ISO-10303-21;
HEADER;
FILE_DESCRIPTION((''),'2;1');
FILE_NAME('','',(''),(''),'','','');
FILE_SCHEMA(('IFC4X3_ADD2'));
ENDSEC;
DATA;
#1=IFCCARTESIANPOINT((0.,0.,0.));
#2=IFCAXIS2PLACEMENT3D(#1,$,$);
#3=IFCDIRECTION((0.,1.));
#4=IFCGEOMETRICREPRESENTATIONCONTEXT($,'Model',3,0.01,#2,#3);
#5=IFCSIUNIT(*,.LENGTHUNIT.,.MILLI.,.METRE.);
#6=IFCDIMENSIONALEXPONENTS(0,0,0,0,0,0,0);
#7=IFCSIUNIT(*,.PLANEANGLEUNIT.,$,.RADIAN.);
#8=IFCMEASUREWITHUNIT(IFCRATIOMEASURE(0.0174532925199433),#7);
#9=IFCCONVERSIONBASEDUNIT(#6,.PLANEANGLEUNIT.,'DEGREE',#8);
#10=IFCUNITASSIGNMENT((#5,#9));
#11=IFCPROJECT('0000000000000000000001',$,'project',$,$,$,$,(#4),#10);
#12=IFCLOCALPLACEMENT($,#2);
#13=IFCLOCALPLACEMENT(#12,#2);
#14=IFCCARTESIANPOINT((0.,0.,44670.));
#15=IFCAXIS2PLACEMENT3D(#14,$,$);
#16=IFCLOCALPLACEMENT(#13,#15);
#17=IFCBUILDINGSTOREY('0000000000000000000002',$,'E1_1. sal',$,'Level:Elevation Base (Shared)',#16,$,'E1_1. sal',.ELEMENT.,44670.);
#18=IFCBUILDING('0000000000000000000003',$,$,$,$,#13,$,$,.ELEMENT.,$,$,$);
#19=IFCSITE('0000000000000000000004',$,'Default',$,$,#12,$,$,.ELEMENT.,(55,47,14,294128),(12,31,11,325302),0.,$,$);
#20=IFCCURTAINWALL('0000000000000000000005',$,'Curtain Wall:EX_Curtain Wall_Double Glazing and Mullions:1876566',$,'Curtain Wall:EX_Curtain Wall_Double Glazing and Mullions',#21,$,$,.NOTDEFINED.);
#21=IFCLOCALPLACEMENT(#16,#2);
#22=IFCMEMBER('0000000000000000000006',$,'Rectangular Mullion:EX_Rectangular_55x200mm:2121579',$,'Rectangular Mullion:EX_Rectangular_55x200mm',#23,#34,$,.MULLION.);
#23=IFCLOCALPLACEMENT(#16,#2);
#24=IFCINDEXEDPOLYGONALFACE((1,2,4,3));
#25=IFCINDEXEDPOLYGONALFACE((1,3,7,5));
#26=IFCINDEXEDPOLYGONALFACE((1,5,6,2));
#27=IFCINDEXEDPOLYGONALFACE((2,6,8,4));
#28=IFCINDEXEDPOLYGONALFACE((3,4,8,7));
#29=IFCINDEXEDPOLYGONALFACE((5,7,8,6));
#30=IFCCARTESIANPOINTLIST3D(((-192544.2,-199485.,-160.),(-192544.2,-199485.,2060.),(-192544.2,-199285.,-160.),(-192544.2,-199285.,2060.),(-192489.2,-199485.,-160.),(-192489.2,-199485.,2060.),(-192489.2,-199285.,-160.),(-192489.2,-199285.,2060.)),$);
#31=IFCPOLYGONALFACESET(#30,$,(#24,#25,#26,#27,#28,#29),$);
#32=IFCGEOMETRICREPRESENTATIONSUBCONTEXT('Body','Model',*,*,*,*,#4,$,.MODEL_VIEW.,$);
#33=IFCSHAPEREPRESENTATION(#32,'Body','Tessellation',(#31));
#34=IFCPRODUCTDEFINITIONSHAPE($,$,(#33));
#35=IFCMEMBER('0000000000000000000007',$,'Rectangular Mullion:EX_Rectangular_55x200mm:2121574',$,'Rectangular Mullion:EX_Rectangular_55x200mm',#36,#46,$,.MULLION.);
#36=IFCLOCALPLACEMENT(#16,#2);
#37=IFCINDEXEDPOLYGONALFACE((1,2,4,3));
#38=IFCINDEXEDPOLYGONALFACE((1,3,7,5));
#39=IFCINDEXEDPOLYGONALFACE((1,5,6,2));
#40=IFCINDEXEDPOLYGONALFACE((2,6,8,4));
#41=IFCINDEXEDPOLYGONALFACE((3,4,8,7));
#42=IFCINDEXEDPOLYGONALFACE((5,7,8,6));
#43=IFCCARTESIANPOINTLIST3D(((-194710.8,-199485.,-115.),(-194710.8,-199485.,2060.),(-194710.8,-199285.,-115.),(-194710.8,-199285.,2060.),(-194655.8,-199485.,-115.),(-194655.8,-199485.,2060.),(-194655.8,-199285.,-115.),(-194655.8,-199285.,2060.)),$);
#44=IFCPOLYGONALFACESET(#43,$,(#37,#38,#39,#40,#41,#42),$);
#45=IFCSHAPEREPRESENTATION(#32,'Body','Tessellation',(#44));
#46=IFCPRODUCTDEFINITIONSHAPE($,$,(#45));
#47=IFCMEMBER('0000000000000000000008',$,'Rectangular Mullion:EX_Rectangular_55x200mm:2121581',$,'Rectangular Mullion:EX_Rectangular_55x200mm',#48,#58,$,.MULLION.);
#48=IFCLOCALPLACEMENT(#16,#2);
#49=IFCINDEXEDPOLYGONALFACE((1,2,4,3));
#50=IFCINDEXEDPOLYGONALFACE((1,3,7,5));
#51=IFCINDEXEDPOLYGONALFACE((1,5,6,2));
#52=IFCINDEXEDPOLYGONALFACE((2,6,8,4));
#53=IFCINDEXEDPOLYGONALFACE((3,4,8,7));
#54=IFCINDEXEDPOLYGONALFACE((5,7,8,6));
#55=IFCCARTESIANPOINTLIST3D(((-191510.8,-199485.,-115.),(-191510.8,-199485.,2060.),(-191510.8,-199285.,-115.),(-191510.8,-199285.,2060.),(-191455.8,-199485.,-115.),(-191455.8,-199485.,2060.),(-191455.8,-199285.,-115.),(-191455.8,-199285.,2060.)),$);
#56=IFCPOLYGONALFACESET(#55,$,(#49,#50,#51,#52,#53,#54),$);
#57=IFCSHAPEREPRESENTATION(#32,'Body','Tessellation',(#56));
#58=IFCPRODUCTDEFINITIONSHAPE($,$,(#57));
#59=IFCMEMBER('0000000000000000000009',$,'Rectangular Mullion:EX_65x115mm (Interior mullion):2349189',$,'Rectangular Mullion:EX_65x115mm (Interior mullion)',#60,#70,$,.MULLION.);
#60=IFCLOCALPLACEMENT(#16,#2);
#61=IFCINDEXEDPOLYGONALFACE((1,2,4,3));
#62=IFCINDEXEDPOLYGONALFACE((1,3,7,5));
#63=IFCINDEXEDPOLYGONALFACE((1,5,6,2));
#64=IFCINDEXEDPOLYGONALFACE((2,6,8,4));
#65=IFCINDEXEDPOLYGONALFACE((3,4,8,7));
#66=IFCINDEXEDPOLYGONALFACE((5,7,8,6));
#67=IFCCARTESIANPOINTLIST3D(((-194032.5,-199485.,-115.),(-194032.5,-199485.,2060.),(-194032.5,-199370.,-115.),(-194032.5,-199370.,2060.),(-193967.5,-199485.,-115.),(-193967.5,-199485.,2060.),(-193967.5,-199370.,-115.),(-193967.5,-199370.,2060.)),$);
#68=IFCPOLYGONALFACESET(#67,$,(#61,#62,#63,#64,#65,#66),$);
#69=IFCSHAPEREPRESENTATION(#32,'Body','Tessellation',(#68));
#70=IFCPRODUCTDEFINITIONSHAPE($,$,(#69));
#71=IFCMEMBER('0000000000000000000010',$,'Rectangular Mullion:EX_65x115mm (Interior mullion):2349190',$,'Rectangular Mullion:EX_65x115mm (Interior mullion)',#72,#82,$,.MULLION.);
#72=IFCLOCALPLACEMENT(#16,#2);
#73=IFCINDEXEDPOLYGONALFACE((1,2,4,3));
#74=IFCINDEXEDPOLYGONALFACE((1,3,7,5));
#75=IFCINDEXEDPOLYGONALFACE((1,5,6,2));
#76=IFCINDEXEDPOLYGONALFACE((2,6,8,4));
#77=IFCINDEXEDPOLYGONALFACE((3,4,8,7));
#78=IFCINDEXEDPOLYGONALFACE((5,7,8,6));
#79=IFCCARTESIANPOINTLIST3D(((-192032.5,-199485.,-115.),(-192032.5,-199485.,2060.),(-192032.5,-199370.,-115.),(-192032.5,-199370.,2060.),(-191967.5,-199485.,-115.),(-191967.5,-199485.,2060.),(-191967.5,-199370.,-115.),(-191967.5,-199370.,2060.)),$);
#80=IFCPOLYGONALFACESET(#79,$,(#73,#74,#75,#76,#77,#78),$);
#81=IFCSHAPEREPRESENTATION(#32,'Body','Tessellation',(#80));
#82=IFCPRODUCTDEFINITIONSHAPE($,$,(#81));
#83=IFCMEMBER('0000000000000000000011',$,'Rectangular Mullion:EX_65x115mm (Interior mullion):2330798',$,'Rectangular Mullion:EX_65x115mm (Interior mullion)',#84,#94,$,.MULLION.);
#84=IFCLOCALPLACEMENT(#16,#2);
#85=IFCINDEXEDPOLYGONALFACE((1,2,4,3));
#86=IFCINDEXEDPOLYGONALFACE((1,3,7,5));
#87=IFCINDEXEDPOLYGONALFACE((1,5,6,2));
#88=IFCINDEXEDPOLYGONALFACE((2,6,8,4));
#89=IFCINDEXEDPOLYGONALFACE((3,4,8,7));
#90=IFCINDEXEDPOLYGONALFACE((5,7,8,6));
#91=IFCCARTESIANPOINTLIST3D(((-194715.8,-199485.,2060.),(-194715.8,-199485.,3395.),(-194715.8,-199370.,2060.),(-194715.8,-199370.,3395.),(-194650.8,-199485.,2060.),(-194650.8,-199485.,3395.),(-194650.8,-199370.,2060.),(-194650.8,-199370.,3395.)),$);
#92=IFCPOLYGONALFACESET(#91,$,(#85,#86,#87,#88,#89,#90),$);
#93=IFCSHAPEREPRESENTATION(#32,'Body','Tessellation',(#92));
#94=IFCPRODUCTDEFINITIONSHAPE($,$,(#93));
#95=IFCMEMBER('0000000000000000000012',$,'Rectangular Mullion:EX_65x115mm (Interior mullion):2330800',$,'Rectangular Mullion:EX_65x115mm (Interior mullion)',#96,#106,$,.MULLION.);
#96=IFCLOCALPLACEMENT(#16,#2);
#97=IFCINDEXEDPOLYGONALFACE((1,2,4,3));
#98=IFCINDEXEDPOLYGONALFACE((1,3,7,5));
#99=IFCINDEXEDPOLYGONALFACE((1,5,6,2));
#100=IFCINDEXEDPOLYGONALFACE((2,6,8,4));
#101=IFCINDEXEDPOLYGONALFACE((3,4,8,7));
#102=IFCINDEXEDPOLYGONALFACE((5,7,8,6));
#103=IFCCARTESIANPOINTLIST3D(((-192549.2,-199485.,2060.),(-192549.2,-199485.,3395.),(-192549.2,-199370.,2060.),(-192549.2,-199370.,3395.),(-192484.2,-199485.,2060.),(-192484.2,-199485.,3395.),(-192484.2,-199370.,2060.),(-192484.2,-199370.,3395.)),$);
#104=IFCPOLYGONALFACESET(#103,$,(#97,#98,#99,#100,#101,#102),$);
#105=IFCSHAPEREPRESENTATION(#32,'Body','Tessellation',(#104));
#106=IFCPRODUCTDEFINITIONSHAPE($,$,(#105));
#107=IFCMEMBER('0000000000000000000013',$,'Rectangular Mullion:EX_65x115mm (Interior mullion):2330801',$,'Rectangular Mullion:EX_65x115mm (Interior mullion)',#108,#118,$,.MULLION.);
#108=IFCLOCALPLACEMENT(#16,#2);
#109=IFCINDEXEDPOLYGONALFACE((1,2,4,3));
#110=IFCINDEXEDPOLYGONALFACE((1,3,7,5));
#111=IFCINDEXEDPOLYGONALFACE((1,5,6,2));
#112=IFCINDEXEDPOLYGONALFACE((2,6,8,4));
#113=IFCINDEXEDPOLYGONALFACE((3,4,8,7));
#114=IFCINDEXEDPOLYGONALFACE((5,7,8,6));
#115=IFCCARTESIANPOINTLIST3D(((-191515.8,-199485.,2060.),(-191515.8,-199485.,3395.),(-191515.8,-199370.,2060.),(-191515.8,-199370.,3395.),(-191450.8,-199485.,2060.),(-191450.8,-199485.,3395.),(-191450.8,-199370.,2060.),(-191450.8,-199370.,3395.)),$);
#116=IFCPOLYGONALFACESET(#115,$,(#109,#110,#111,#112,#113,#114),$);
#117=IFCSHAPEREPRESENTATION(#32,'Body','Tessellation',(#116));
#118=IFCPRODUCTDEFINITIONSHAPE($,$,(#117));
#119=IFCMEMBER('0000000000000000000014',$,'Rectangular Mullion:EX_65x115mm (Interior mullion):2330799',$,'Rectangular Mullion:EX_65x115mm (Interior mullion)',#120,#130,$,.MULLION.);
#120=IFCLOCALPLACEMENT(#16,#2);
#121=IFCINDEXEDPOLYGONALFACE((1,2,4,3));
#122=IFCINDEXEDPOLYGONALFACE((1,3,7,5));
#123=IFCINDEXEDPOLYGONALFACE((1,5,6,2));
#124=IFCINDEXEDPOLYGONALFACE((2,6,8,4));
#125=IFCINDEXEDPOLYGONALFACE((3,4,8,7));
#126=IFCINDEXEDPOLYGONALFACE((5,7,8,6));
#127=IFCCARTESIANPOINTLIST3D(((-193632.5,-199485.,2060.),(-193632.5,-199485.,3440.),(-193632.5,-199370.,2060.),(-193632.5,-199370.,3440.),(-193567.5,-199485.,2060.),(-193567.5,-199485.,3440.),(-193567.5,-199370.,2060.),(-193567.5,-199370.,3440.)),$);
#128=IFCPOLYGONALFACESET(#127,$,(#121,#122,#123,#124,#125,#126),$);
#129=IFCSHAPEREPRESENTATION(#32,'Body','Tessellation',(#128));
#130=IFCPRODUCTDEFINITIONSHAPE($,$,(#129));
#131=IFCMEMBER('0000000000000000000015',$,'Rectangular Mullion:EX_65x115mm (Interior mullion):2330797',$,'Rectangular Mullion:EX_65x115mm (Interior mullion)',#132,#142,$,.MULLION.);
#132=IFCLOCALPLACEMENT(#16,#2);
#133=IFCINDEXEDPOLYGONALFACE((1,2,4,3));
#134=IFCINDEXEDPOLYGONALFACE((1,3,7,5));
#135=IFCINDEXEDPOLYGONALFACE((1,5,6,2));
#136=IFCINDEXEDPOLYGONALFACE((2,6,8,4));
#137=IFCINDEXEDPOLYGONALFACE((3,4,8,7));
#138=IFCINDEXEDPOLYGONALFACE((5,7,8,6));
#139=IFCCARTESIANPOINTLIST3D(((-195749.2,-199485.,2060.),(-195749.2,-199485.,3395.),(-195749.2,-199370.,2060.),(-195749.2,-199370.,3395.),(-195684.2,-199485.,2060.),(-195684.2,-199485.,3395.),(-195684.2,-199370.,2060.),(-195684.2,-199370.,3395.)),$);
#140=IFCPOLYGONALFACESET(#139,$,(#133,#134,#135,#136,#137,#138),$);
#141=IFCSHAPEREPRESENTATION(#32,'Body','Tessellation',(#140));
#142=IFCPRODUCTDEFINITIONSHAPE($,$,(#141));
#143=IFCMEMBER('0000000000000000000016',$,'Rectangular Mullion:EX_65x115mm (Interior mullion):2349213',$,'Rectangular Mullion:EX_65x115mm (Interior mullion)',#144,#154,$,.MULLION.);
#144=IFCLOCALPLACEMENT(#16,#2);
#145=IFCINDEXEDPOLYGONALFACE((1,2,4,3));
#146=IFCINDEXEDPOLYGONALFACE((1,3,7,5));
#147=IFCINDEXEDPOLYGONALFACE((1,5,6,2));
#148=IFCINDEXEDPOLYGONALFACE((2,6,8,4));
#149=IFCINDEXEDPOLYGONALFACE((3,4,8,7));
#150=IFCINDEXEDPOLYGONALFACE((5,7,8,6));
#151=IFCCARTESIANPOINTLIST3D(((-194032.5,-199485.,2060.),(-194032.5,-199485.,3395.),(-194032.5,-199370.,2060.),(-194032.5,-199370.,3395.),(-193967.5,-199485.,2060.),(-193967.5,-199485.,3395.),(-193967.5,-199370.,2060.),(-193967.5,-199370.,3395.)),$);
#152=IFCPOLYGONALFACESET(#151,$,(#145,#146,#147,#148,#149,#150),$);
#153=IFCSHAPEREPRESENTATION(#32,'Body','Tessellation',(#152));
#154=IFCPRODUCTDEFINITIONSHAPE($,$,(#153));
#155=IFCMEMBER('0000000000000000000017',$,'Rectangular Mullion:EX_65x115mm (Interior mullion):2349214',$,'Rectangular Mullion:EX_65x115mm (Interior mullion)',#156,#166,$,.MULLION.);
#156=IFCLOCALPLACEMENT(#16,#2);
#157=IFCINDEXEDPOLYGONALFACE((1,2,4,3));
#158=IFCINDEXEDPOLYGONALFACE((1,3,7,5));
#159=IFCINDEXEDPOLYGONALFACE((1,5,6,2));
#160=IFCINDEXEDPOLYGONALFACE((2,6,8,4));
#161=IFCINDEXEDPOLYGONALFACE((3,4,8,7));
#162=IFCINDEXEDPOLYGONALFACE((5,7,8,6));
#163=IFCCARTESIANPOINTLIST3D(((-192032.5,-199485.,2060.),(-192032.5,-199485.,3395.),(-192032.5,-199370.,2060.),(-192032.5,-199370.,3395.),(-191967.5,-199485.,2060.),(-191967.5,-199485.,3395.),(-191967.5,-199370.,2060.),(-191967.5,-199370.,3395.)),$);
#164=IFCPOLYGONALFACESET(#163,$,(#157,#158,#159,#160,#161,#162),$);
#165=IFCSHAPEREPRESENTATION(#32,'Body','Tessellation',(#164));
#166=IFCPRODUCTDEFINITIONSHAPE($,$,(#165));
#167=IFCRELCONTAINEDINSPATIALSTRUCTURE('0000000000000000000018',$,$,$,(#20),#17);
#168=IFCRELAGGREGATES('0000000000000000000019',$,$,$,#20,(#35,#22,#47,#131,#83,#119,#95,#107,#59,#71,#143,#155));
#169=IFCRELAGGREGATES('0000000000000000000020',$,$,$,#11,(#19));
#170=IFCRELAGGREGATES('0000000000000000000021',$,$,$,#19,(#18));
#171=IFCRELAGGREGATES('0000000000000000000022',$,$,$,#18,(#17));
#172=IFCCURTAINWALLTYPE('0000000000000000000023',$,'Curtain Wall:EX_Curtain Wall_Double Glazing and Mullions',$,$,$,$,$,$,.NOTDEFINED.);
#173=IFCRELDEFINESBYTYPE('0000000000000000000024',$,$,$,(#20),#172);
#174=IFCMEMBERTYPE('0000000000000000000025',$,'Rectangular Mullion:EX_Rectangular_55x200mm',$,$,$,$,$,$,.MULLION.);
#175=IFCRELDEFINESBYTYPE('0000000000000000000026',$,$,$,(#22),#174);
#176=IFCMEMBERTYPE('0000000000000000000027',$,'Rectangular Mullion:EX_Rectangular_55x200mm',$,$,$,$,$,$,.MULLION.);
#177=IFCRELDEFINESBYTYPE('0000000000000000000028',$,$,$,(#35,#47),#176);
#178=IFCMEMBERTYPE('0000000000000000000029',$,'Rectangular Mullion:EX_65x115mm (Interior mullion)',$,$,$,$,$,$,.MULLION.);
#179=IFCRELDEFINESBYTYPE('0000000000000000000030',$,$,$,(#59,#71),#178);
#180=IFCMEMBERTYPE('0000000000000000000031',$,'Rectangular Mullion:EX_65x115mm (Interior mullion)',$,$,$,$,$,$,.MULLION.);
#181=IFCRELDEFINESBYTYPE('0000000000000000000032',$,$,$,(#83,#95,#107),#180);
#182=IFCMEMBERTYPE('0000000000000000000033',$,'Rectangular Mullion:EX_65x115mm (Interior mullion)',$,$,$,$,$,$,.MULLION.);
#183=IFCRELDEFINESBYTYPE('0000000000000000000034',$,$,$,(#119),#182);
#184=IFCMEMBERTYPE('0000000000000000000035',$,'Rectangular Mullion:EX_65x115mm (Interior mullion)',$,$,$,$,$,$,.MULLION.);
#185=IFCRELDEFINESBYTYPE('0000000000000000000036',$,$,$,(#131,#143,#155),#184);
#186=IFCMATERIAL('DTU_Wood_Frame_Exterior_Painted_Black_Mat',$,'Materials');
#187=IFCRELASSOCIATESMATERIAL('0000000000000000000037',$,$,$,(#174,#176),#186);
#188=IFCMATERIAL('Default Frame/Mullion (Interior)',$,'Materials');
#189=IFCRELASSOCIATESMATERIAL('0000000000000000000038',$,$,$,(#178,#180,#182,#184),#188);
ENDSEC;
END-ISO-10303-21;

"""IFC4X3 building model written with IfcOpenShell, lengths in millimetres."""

from ifc_helpers import new_model, entity, si_unit, converted_unit, direction, frame, origin, origin_2d_with_axis, place, context, subcontext, project, spatial, rectangle, extrude, source, transform, mapped, material, material_profile, profile_set, type_object, type_shapes, element, aggregate, save


model = new_model("IFC4X3")

# Units and contexts
model_context = context("Model", 3, precision=0.01, world=origin(), true_north=direction((0.0, 1.0)))
body_context = subcontext(model_context, "Body", "Model", "MODEL_VIEW")
ifc_project = project(units=[si_unit("LENGTHUNIT", "METRE", prefix="MILLI"), converted_unit("PLANEANGLEUNIT", "DEGREE", entity("IfcRatioMeasure", 0.0174532925199433), si_unit("PLANEANGLEUNIT", "RADIAN"), dimensions=[0, 0, 0, 0, 0, 0, 0])], contexts=[model_context])

# Site, building, storey
site_placement = place(None, origin())
site = spatial("IfcSite", under=ifc_project, at=site_placement, Name="Default", CompositionType="ELEMENT", RefLatitude=(55, 47, 14, 294128), RefLongitude=(12, 31, 11, 325302), RefElevation=0.0)
building_placement = place(site_placement, origin())
building = spatial("IfcBuilding", under=site, at=building_placement, CompositionType="ELEMENT")
storey_placement = place(building_placement, frame((0.0, 0.0, 44670.0)))
storey = spatial("IfcBuildingStorey", under=building, at=storey_placement, Name="E1_1. sal", ObjectType="Level:Elevation Base (Shared)", LongName="E1_1. sal", CompositionType="ELEMENT", Elevation=44670.0)

# Curtain wall, members
curtain_wall_type = type_object("IfcCurtainWallType", Name="Curtain Wall:EX_Curtain Wall_Double Glazing and Mullions", PredefinedType="NOTDEFINED")
curtain_wall_placement = place(storey_placement, frame((0.0, 0.0, -44670.0)))
curtain_wall = element("IfcCurtainWall", 1, at=curtain_wall_placement, inside=storey, type_object=curtain_wall_type, Name="Curtain Wall:EX_Curtain Wall_Double Glazing and Mullions:1876566", ObjectType="Curtain Wall:EX_Curtain Wall_Double Glazing and Mullions", PredefinedType="NOTDEFINED")
ifc_material_1 = material(Name="DTU_Wood_Frame_Exterior_Painted_Black_Mat", Category="Materials")
ifc_material_profile_1 = material_profile(ifc_material_1, rectangle(XDim=200.0, YDim=55.0, at=origin_2d_with_axis()), Name="EX_Rectangular_55x200mm")
ifc_profile_set_1 = profile_set([ifc_material_profile_1], Name="EX_Rectangular_55x200mm")
member_type_1 = type_object("IfcMemberType", Name="Rectangular Mullion:EX_Rectangular_55x200mm", PredefinedType="MULLION", material=ifc_profile_set_1)
shared_shape_1 = source(origin(), body_context, "Body", "SweptSolid", [
    extrude(rectangle(XDim=200.0, YDim=55.0, at=origin_2d_with_axis()), frame((0.0, -100.0, -2220.0), z_axis=(0.0, 0.0, 1.0), x_axis=(0.0, -1.0, 0.0)), (0.0, 0.0, 1.0), 2220.0),
])
type_shapes(member_type_1, [shared_shape_1])
member_1_placement = place(curtain_wall_placement, frame((-192516.7, -199485.0, 44510.0), z_axis=(0.0, 0.0, -1.0), x_axis=(1.0, 0.0, 0.0)))
member_1 = element("IfcMember", 2, at=member_1_placement, type_object=member_type_1, Name="Rectangular Mullion:EX_Rectangular_55x200mm:2121579", ObjectType="Rectangular Mullion:EX_Rectangular_55x200mm", PredefinedType="MULLION", context=body_context, shape_type="MappedRepresentation", body=[
    mapped(shared_shape_1, transform((0.0, 0.0, 0.0), scale=1.0)),
])
member_type_2 = type_object("IfcMemberType", Name="Rectangular Mullion:EX_Rectangular_55x200mm", PredefinedType="MULLION", material=ifc_profile_set_1)
shared_shape_2 = source(origin(), body_context, "Body", "SweptSolid", [
    extrude(rectangle(XDim=200.0, YDim=55.0, at=origin_2d_with_axis()), frame((0.0, -100.0, -2175.0), z_axis=(0.0, 0.0, 1.0), x_axis=(0.0, -1.0, 0.0)), (0.0, 0.0, 1.0), 2175.0),
])
type_shapes(member_type_2, [shared_shape_2])
member_2_placement = place(curtain_wall_placement, frame((-194683.3, -199485.0, 44555.0), z_axis=(0.0, 0.0, -1.0), x_axis=(1.0, 0.0, 0.0)))
member_2 = element("IfcMember", 3, at=member_2_placement, type_object=member_type_2, Name="Rectangular Mullion:EX_Rectangular_55x200mm:2121574", ObjectType="Rectangular Mullion:EX_Rectangular_55x200mm", PredefinedType="MULLION", context=body_context, shape_type="MappedRepresentation", body=[
    mapped(shared_shape_2, transform((0.0, 0.0, 0.0), scale=1.0)),
])
member_3_placement = place(curtain_wall_placement, frame((-191483.3, -199485.0, 44555.0), z_axis=(0.0, 0.0, -1.0), x_axis=(1.0, 0.0, 0.0)))
member_3 = element("IfcMember", 4, at=member_3_placement, type_object=member_type_2, Name="Rectangular Mullion:EX_Rectangular_55x200mm:2121581", ObjectType="Rectangular Mullion:EX_Rectangular_55x200mm", PredefinedType="MULLION", context=body_context, shape_type="MappedRepresentation", body=[
    mapped(shared_shape_2, transform((0.0, 0.0, 0.0), scale=1.0)),
])
ifc_material_2 = material(Name="Default Frame/Mullion (Interior)", Category="Materials")
ifc_material_profile_2 = material_profile(ifc_material_2, rectangle(XDim=115.0, YDim=65.0, at=origin_2d_with_axis()), Name="EX_65x115mm (Interior mullion)")
ifc_profile_set_2 = profile_set([ifc_material_profile_2], Name="EX_65x115mm (Interior mullion)")
member_type_3 = type_object("IfcMemberType", Name="Rectangular Mullion:EX_65x115mm (Interior mullion)", PredefinedType="MULLION", material=ifc_profile_set_2)
shared_shape_3 = source(origin(), body_context, "Body", "SweptSolid", [
    extrude(rectangle(XDim=115.0, YDim=65.0, at=origin_2d_with_axis()), frame((0.0, -57.5, -2175.0), z_axis=(0.0, 0.0, 1.0), x_axis=(0.0, -1.0, 0.0)), (0.0, 0.0, 1.0), 2175.0),
])
type_shapes(member_type_3, [shared_shape_3])
member_4_placement = place(curtain_wall_placement, frame((-194000.0, -199485.0, 44555.0), z_axis=(0.0, 0.0, -1.0), x_axis=(1.0, 0.0, 0.0)))
member_4 = element("IfcMember", 5, at=member_4_placement, type_object=member_type_3, Name="Rectangular Mullion:EX_65x115mm (Interior mullion):2349189", ObjectType="Rectangular Mullion:EX_65x115mm (Interior mullion)", PredefinedType="MULLION", context=body_context, shape_type="MappedRepresentation", body=[
    mapped(shared_shape_3, transform((0.0, 0.0, 0.0), scale=1.0)),
])
member_5_placement = place(curtain_wall_placement, frame((-192000.0, -199485.0, 44555.0), z_axis=(0.0, 0.0, -1.0), x_axis=(1.0, 0.0, 0.0)))
member_5 = element("IfcMember", 6, at=member_5_placement, type_object=member_type_3, Name="Rectangular Mullion:EX_65x115mm (Interior mullion):2349190", ObjectType="Rectangular Mullion:EX_65x115mm (Interior mullion)", PredefinedType="MULLION", context=body_context, shape_type="MappedRepresentation", body=[
    mapped(shared_shape_3, transform((0.0, 0.0, 0.0), scale=1.0)),
])
member_type_4 = type_object("IfcMemberType", Name="Rectangular Mullion:EX_65x115mm (Interior mullion)", PredefinedType="MULLION", material=ifc_profile_set_2)
shared_shape_4 = source(origin(), body_context, "Body", "SweptSolid", [
    extrude(rectangle(XDim=115.0, YDim=65.0, at=origin_2d_with_axis()), frame((0.0, -57.5, -1335.0), z_axis=(0.0, 0.0, 1.0), x_axis=(0.0, -1.0, 0.0)), (0.0, 0.0, 1.0), 1335.0),
])
type_shapes(member_type_4, [shared_shape_4])
member_6_placement = place(curtain_wall_placement, frame((-194683.3, -199485.0, 46730.0), z_axis=(0.0, 0.0, -1.0), x_axis=(1.0, 0.0, 0.0)))
member_6 = element("IfcMember", 7, at=member_6_placement, type_object=member_type_4, Name="Rectangular Mullion:EX_65x115mm (Interior mullion):2330798", ObjectType="Rectangular Mullion:EX_65x115mm (Interior mullion)", PredefinedType="MULLION", context=body_context, shape_type="MappedRepresentation", body=[
    mapped(shared_shape_4, transform((0.0, 0.0, 0.0), scale=1.0)),
])
member_7_placement = place(curtain_wall_placement, frame((-192516.7, -199485.0, 46730.0), z_axis=(0.0, 0.0, -1.0), x_axis=(1.0, 0.0, 0.0)))
member_7 = element("IfcMember", 8, at=member_7_placement, type_object=member_type_4, Name="Rectangular Mullion:EX_65x115mm (Interior mullion):2330800", ObjectType="Rectangular Mullion:EX_65x115mm (Interior mullion)", PredefinedType="MULLION", context=body_context, shape_type="MappedRepresentation", body=[
    mapped(shared_shape_4, transform((0.0, 0.0, 0.0), scale=1.0)),
])
member_8_placement = place(curtain_wall_placement, frame((-191483.3, -199485.0, 46730.0), z_axis=(0.0, 0.0, -1.0), x_axis=(1.0, 0.0, 0.0)))
member_8 = element("IfcMember", 9, at=member_8_placement, type_object=member_type_4, Name="Rectangular Mullion:EX_65x115mm (Interior mullion):2330801", ObjectType="Rectangular Mullion:EX_65x115mm (Interior mullion)", PredefinedType="MULLION", context=body_context, shape_type="MappedRepresentation", body=[
    mapped(shared_shape_4, transform((0.0, 0.0, 0.0), scale=1.0)),
])
member_type_5 = type_object("IfcMemberType", Name="Rectangular Mullion:EX_65x115mm (Interior mullion)", PredefinedType="MULLION", material=ifc_profile_set_2)
shared_shape_5 = source(origin(), body_context, "Body", "SweptSolid", [
    extrude(rectangle(XDim=115.0, YDim=65.0, at=origin_2d_with_axis()), frame((0.0, -57.5, -1380.0), z_axis=(0.0, 0.0, 1.0), x_axis=(0.0, -1.0, 0.0)), (0.0, 0.0, 1.0), 1380.0),
])
type_shapes(member_type_5, [shared_shape_5])
member_9_placement = place(curtain_wall_placement, frame((-193600.0, -199485.0, 46730.0), z_axis=(0.0, 0.0, -1.0), x_axis=(1.0, 0.0, 0.0)))
member_9 = element("IfcMember", 10, at=member_9_placement, type_object=member_type_5, Name="Rectangular Mullion:EX_65x115mm (Interior mullion):2330799", ObjectType="Rectangular Mullion:EX_65x115mm (Interior mullion)", PredefinedType="MULLION", context=body_context, shape_type="MappedRepresentation", body=[
    mapped(shared_shape_5, transform((0.0, 0.0, 0.0), scale=1.0)),
])
member_type_6 = type_object("IfcMemberType", Name="Rectangular Mullion:EX_65x115mm (Interior mullion)", PredefinedType="MULLION", material=ifc_profile_set_2)
shared_shape_6 = source(origin(), body_context, "Body", "SweptSolid", [
    extrude(rectangle(XDim=115.0, YDim=65.0, at=origin_2d_with_axis()), frame((0.0, -57.5, -1335.0), z_axis=(0.0, 0.0, 1.0), x_axis=(0.0, -1.0, 0.0)), (0.0, 0.0, 1.0), 1335.0),
])
type_shapes(member_type_6, [shared_shape_6])
member_10_placement = place(curtain_wall_placement, frame((-195716.7, -199485.0, 46730.0), z_axis=(0.0, 0.0, -1.0), x_axis=(1.0, 0.0, 0.0)))
member_10 = element("IfcMember", 11, at=member_10_placement, type_object=member_type_6, Name="Rectangular Mullion:EX_65x115mm (Interior mullion):2330797", ObjectType="Rectangular Mullion:EX_65x115mm (Interior mullion)", PredefinedType="MULLION", context=body_context, shape_type="MappedRepresentation", body=[
    mapped(shared_shape_6, transform((0.0, 0.0, 0.0), scale=1.0)),
])
member_11_placement = place(curtain_wall_placement, frame((-194000.0, -199485.0, 46730.0), z_axis=(0.0, 0.0, -1.0), x_axis=(1.0, 0.0, 0.0)))
member_11 = element("IfcMember", 12, at=member_11_placement, type_object=member_type_6, Name="Rectangular Mullion:EX_65x115mm (Interior mullion):2349213", ObjectType="Rectangular Mullion:EX_65x115mm (Interior mullion)", PredefinedType="MULLION", context=body_context, shape_type="MappedRepresentation", body=[
    mapped(shared_shape_6, transform((0.0, 0.0, 0.0), scale=1.0)),
])
member_12_placement = place(curtain_wall_placement, frame((-192000.0, -199485.0, 46730.0), z_axis=(0.0, 0.0, -1.0), x_axis=(1.0, 0.0, 0.0)))
member_12 = element("IfcMember", 13, at=member_12_placement, type_object=member_type_6, Name="Rectangular Mullion:EX_65x115mm (Interior mullion):2349214", ObjectType="Rectangular Mullion:EX_65x115mm (Interior mullion)", PredefinedType="MULLION", context=body_context, shape_type="MappedRepresentation", body=[
    mapped(shared_shape_6, transform((0.0, 0.0, 0.0), scale=1.0)),
])
aggregate(curtain_wall, [member_2, member_1, member_3, member_10, member_6, member_9, member_7, member_8, member_4, member_5, member_11, member_12])

save(model, "model.ifc")
